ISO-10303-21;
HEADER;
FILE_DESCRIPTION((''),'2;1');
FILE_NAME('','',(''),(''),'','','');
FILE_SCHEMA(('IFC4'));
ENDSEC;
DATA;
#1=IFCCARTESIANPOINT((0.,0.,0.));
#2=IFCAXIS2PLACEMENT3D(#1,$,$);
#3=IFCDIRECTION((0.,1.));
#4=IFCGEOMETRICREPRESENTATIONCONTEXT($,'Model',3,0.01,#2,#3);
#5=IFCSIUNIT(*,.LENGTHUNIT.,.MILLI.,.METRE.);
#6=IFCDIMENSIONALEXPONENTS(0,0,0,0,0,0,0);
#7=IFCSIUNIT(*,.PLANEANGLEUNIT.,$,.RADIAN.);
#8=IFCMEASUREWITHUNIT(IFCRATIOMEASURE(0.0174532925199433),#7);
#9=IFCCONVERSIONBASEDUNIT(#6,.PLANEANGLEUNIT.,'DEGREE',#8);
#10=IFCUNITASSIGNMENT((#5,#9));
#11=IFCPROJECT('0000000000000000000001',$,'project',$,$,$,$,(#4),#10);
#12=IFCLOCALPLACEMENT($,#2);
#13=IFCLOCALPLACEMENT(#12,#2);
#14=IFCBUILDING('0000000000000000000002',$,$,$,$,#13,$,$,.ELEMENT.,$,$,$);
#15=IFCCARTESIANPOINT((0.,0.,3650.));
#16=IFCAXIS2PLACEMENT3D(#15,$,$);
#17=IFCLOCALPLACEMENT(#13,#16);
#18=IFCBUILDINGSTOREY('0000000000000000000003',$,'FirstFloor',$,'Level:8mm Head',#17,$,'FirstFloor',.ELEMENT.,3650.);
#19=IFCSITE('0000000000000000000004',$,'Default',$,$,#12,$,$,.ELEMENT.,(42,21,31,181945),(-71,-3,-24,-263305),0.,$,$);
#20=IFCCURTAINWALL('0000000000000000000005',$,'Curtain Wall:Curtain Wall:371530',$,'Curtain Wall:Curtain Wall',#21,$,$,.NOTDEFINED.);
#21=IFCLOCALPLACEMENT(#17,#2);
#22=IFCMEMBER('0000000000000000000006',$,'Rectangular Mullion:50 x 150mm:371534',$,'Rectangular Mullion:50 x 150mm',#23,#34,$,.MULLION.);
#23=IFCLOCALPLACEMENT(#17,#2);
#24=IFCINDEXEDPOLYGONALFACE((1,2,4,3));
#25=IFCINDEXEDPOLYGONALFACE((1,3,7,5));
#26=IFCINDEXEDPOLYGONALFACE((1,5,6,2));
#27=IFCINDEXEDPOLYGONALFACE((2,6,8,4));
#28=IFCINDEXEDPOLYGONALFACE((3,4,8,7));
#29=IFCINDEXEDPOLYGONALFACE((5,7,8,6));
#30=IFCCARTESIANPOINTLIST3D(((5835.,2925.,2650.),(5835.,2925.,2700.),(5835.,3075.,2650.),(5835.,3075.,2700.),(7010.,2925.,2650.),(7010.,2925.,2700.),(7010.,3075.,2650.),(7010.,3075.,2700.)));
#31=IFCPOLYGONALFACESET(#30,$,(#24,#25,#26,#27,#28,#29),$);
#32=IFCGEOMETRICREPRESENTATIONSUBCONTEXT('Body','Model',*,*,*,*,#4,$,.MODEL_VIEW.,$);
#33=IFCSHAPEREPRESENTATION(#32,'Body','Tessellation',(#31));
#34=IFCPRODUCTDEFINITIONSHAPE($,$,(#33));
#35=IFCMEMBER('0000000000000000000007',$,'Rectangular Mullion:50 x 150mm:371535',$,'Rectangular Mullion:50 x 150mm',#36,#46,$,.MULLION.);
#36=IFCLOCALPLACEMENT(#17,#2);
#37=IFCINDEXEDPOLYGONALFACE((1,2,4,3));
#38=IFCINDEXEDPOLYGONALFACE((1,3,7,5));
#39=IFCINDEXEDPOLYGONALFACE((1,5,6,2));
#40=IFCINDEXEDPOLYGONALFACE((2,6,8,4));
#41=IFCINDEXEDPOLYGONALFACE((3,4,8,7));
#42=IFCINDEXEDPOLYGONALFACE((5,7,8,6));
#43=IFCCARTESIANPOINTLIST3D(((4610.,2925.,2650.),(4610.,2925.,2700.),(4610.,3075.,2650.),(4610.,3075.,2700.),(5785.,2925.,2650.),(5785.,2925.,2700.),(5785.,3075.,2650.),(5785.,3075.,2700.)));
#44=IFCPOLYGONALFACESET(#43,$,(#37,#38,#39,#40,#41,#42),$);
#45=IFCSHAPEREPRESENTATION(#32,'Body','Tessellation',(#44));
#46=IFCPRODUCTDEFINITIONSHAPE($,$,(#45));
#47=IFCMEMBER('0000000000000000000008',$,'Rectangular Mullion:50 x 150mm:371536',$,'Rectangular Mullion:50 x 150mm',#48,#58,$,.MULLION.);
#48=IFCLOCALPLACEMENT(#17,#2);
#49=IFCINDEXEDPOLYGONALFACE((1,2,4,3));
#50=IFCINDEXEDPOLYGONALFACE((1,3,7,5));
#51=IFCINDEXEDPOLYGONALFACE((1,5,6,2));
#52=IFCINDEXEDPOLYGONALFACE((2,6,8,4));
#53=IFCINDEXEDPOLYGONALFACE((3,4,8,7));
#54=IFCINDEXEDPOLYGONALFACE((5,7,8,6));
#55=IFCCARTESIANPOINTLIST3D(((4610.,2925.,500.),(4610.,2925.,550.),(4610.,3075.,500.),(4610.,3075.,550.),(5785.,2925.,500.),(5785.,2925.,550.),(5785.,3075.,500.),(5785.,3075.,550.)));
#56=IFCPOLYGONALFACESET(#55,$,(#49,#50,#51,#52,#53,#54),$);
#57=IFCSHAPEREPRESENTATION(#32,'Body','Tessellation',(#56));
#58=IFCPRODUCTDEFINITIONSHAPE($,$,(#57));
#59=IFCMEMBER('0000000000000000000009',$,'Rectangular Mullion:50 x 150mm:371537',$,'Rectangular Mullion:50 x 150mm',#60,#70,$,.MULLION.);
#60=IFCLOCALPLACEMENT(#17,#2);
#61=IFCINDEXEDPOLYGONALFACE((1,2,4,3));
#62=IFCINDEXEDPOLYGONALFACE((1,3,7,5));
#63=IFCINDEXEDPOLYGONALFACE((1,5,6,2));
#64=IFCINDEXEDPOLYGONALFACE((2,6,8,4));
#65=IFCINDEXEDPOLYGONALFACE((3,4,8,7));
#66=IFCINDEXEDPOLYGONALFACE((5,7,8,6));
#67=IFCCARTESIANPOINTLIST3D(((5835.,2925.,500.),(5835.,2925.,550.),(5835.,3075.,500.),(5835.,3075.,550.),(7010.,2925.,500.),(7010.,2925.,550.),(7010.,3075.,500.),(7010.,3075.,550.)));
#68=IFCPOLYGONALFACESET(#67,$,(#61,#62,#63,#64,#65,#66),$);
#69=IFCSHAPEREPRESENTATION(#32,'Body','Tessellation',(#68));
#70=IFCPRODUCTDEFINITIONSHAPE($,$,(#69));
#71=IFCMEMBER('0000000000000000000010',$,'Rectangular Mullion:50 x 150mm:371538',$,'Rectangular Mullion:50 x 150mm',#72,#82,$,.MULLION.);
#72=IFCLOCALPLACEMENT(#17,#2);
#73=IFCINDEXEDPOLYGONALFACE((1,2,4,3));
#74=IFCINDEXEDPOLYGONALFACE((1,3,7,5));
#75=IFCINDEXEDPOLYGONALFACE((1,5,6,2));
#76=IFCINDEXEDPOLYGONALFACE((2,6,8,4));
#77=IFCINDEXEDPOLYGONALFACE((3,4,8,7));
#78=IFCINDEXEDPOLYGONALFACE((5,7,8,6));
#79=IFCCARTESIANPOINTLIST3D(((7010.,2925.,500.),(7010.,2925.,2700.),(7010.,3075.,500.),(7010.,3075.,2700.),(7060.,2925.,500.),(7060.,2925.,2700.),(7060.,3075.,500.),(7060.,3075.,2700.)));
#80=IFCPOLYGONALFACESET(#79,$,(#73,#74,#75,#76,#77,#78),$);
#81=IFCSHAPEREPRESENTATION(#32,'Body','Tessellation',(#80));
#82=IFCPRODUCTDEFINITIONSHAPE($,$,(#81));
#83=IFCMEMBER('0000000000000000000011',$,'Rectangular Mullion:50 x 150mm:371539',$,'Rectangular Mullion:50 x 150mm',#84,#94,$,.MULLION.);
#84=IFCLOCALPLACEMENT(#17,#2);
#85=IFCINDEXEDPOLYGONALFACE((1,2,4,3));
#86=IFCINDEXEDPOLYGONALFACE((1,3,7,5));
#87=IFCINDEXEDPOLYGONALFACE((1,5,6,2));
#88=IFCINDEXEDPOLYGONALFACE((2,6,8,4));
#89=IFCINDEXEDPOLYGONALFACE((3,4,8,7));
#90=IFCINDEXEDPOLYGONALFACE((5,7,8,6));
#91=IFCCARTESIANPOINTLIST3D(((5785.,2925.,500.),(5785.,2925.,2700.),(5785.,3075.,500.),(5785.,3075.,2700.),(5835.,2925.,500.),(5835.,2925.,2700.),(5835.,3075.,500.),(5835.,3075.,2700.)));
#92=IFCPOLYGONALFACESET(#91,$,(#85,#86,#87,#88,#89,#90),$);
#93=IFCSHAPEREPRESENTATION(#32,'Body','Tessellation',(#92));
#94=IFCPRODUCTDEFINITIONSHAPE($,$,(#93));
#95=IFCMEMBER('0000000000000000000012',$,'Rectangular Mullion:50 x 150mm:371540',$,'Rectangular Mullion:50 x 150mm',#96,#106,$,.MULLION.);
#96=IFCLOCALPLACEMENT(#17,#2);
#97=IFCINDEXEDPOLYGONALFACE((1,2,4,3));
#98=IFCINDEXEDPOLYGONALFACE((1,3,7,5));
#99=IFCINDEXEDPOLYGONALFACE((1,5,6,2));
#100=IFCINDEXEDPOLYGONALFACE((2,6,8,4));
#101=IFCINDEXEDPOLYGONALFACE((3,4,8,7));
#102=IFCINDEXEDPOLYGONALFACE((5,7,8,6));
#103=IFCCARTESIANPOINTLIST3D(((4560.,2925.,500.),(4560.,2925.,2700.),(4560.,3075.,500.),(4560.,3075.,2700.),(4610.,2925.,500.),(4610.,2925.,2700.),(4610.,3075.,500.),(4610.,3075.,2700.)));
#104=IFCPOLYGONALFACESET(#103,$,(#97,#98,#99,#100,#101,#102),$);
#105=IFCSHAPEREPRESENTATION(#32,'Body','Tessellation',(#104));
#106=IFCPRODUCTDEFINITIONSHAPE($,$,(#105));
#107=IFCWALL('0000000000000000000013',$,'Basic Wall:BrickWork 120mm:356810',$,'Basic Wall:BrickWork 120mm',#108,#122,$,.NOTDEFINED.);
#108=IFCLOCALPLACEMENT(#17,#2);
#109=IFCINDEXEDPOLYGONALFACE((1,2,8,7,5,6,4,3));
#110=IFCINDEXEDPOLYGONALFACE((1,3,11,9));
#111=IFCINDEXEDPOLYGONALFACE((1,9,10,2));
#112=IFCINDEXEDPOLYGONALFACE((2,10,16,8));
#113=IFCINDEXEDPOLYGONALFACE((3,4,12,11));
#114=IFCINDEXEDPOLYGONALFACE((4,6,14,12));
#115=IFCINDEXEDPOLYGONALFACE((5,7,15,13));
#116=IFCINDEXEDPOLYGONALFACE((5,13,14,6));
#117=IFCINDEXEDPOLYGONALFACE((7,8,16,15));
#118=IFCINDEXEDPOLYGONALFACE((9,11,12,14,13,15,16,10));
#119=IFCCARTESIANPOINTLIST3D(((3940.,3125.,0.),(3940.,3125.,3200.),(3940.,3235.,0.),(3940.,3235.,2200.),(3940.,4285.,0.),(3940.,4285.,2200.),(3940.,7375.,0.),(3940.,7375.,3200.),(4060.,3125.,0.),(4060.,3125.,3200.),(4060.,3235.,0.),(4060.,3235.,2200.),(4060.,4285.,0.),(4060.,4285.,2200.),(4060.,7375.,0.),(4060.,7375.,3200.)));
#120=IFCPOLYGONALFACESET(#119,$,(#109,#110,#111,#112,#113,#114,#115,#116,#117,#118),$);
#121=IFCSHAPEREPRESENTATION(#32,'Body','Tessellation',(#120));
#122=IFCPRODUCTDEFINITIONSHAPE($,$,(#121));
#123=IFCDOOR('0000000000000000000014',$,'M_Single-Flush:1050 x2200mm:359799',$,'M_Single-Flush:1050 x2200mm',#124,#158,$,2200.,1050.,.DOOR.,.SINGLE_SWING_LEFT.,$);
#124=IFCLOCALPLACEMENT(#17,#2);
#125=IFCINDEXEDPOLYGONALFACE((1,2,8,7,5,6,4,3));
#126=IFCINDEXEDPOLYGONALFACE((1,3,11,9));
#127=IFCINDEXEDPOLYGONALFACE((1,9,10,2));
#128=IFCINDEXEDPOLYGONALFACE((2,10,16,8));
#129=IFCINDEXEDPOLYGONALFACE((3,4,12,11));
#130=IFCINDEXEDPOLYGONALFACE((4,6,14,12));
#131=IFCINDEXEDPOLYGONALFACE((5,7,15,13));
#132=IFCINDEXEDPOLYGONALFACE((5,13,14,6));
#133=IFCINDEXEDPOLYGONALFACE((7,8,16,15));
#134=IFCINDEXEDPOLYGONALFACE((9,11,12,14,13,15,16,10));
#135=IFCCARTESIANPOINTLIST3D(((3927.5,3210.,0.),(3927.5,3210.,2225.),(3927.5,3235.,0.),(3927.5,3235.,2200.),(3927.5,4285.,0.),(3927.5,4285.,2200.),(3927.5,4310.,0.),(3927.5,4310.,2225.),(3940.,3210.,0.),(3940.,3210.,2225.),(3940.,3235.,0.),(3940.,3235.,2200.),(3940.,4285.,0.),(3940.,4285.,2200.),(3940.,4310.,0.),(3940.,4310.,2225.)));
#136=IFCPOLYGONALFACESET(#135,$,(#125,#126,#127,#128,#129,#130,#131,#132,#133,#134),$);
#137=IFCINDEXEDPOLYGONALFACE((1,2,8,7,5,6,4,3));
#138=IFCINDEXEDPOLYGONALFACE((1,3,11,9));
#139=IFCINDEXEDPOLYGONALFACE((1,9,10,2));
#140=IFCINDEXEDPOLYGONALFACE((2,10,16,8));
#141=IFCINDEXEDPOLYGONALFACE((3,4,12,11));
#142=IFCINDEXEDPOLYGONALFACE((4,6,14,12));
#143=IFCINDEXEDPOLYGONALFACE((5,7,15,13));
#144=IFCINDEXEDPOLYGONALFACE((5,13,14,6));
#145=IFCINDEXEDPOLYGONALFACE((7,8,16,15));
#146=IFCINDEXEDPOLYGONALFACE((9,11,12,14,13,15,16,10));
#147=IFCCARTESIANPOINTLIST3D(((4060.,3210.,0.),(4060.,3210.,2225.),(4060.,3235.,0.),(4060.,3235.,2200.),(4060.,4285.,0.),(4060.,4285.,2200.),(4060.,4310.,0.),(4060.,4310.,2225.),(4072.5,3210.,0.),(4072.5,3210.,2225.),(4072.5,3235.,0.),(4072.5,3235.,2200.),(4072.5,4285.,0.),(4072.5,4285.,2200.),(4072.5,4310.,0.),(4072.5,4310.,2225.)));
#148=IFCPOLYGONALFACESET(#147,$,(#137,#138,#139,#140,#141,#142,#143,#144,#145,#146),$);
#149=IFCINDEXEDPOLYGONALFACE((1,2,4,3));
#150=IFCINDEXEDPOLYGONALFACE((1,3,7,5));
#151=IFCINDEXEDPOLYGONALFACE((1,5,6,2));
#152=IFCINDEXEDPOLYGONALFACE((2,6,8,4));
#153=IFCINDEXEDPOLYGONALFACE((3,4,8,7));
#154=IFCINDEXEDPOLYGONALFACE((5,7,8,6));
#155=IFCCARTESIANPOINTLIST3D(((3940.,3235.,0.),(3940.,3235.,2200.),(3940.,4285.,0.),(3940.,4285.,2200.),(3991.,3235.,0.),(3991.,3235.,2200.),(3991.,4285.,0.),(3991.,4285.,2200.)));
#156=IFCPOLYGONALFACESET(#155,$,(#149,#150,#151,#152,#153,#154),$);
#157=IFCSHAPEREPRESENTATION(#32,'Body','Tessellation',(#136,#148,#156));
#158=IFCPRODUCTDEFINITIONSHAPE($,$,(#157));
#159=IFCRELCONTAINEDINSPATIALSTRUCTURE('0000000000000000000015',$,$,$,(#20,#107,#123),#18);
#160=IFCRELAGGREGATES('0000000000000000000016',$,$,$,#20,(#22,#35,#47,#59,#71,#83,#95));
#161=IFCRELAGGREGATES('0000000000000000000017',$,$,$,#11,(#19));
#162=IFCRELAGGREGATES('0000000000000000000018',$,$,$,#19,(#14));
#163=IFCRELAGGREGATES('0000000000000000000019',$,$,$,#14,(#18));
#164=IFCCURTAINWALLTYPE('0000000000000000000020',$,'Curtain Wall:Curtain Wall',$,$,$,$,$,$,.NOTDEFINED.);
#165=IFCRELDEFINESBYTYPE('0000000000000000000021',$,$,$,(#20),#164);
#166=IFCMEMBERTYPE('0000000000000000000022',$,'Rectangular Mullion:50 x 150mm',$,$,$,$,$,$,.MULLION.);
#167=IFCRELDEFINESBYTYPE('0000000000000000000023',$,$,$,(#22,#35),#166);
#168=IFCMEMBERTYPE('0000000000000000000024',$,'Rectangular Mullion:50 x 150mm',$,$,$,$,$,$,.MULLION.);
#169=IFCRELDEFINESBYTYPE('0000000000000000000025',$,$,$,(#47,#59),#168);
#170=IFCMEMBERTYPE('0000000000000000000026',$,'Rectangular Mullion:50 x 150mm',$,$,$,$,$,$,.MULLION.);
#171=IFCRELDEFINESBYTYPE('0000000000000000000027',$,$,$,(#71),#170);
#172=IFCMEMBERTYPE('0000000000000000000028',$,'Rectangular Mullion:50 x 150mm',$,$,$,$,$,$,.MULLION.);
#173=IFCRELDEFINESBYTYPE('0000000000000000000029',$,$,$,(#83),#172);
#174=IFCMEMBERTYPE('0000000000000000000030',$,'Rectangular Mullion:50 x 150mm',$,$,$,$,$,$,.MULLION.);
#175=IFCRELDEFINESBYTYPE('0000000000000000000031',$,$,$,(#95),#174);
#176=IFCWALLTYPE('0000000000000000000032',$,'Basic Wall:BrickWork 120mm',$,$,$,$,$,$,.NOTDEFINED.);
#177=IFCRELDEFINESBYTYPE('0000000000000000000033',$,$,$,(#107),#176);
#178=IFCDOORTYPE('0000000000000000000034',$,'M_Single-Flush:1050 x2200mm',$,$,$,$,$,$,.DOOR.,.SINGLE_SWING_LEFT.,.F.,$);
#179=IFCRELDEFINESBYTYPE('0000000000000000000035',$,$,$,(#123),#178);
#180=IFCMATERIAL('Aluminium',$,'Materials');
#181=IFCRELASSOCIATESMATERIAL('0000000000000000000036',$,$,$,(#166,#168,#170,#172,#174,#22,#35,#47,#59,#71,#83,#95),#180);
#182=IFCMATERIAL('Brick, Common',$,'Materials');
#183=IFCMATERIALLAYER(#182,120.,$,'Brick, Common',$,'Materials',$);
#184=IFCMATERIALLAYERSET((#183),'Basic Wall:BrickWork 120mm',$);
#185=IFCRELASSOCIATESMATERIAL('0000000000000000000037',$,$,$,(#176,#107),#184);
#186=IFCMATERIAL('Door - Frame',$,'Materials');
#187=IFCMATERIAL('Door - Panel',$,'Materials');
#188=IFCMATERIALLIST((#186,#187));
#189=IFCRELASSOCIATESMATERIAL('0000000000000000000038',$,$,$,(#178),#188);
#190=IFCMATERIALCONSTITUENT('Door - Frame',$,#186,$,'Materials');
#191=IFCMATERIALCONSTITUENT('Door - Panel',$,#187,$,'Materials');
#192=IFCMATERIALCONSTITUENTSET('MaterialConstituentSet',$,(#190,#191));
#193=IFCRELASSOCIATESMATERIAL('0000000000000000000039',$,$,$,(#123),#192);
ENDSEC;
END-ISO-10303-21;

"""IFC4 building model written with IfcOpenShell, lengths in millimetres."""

from ifc_helpers import new_model, entity, si_unit, converted_unit, direction, frame, frame_2d, origin, origin_2d_with_axis, place, context, subcontext, project, spatial, polyline, rectangle, outline, extrude, source, transform, mapped, material, material_list, layer, layer_set, layer_usage, constituent, constituent_set, material_profile, profile_set, profile_usage, type_object, type_shapes, element, fill, aggregate, save


model = new_model("IFC4")

# Units and contexts
model_context = context("Model", 3, precision=0.01, world=origin(), true_north=direction((0.0, 1.0)))
body_context = subcontext(model_context, "Body", "Model", "MODEL_VIEW")
ifc_project = project(units=[si_unit("LENGTHUNIT", "METRE", prefix="MILLI"), converted_unit("PLANEANGLEUNIT", "DEGREE", entity("IfcRatioMeasure", 0.0174532925199433), si_unit("PLANEANGLEUNIT", "RADIAN"), dimensions=[0, 0, 0, 0, 0, 0, 0])], contexts=[model_context])

# Site, building, storey
site_placement = place(None, origin())
site = spatial("IfcSite", under=ifc_project, at=site_placement, Name="Default", CompositionType="ELEMENT", RefLatitude=(42, 21, 31, 181945), RefLongitude=(-71, -3, -24, -263305), RefElevation=0.0)
building_placement = place(site_placement, origin())
building = spatial("IfcBuilding", under=site, at=building_placement, CompositionType="ELEMENT")
storey_placement = place(building_placement, frame((0.0, 0.0, 3650.0)))
storey = spatial("IfcBuildingStorey", under=building, at=storey_placement, Name="FirstFloor", ObjectType="Level:8mm Head", LongName="FirstFloor", CompositionType="ELEMENT", Elevation=3650.0)

# Curtain wall, members
curtain_wall_type = type_object("IfcCurtainWallType", Name="Curtain Wall:Curtain Wall", PredefinedType="NOTDEFINED")
curtain_wall_placement = place(storey_placement, frame((0.0, 0.0, -3650.0)))
curtain_wall = element("IfcCurtainWall", 1, at=curtain_wall_placement, inside=storey, type_object=curtain_wall_type, Name="Curtain Wall:Curtain Wall:371530", ObjectType="Curtain Wall:Curtain Wall", PredefinedType="NOTDEFINED")
ifc_material_1 = material(Name="Aluminium", Category="Materials")
ifc_material_profile = material_profile(ifc_material_1, rectangle(XDim=150.0, YDim=50.0, at=origin_2d_with_axis()), Name="50 x 150mm")
ifc_profile_set = profile_set([ifc_material_profile], Name="50 x 150mm")
ifc_profile_usage_1 = profile_usage(ifc_profile_set)
member_type_1 = type_object("IfcMemberType", Name="Rectangular Mullion:50 x 150mm", PredefinedType="MULLION", material=ifc_profile_set)
shared_shape_1 = source(origin(), body_context, "Body", "SweptSolid", [
    extrude(rectangle(XDim=150.0, YDim=50.0, at=origin_2d_with_axis()), frame((-25.0, 0.0, -1175.0), z_axis=(0.0, 0.0, 1.0), x_axis=(0.0, -1.0, 0.0)), (0.0, 0.0, 1.0), 1175.0),
])
type_shapes(member_type_1, [shared_shape_1])
member_1_placement = place(storey_placement, frame((7010.0, 3000.0, 2700.0), z_axis=(1.0, 0.0, 0.0), x_axis=(0.0, 0.0, 1.0)))
member_1 = element("IfcMember", 2, at=member_1_placement, type_object=member_type_1, material=ifc_profile_usage_1, Name="Rectangular Mullion:50 x 150mm:371534", ObjectType="Rectangular Mullion:50 x 150mm", PredefinedType="MULLION", context=body_context, shape_type="MappedRepresentation", body=[
    mapped(shared_shape_1, transform((0.0, 0.0, 0.0), scale=1.0)),
])
ifc_profile_usage_2 = profile_usage(ifc_profile_set)
member_2_placement = place(storey_placement, frame((5785.0, 3000.0, 2700.0), z_axis=(1.0, 0.0, 0.0), x_axis=(0.0, 0.0, 1.0)))
member_2 = element("IfcMember", 3, at=member_2_placement, type_object=member_type_1, material=ifc_profile_usage_2, Name="Rectangular Mullion:50 x 150mm:371535", ObjectType="Rectangular Mullion:50 x 150mm", PredefinedType="MULLION", context=body_context, shape_type="MappedRepresentation", body=[
    mapped(shared_shape_1, transform((0.0, 0.0, 0.0), scale=1.0)),
])
ifc_profile_usage_3 = profile_usage(ifc_profile_set)
member_type_2 = type_object("IfcMemberType", Name="Rectangular Mullion:50 x 150mm", PredefinedType="MULLION", material=ifc_profile_set)
shared_shape_2 = source(origin(), body_context, "Body", "SweptSolid", [
    extrude(rectangle(XDim=150.0, YDim=50.0, at=origin_2d_with_axis()), frame((-25.0, 0.0, -1175.0), z_axis=(0.0, 0.0, 1.0), x_axis=(0.0, -1.0, 0.0)), (0.0, 0.0, 1.0), 1175.0),
])
type_shapes(member_type_2, [shared_shape_2])
member_3_placement = place(storey_placement, frame((4610.0, 3000.0, 500.0), z_axis=(-1.0, 0.0, 0.0), x_axis=(0.0, 0.0, -1.0)))
member_3 = element("IfcMember", 4, at=member_3_placement, type_object=member_type_2, material=ifc_profile_usage_3, Name="Rectangular Mullion:50 x 150mm:371536", ObjectType="Rectangular Mullion:50 x 150mm", PredefinedType="MULLION", context=body_context, shape_type="MappedRepresentation", body=[
    mapped(shared_shape_2, transform((0.0, 0.0, 0.0), scale=1.0)),
])
ifc_profile_usage_4 = profile_usage(ifc_profile_set)
member_4_placement = place(storey_placement, frame((5835.0, 3000.0, 500.0), z_axis=(-1.0, 0.0, 0.0), x_axis=(0.0, 0.0, -1.0)))
member_4 = element("IfcMember", 5, at=member_4_placement, type_object=member_type_2, material=ifc_profile_usage_4, Name="Rectangular Mullion:50 x 150mm:371537", ObjectType="Rectangular Mullion:50 x 150mm", PredefinedType="MULLION", context=body_context, shape_type="MappedRepresentation", body=[
    mapped(shared_shape_2, transform((0.0, 0.0, 0.0), scale=1.0)),
])
ifc_profile_usage_5 = profile_usage(ifc_profile_set)
member_type_3 = type_object("IfcMemberType", Name="Rectangular Mullion:50 x 150mm", PredefinedType="MULLION", material=ifc_profile_set)
shared_shape_3 = source(origin(), body_context, "Body", "SweptSolid", [
    extrude(rectangle(XDim=150.0, YDim=50.0, at=origin_2d_with_axis()), frame((-25.0, 0.0, -2200.0), z_axis=(0.0, 0.0, 1.0), x_axis=(0.0, -1.0, 0.0)), (0.0, 0.0, 1.0), 2200.0),
])
type_shapes(member_type_3, [shared_shape_3])
member_5_placement = place(storey_placement, frame((7060.0, 3000.0, 500.0), z_axis=(0.0, 0.0, -1.0), x_axis=(1.0, 0.0, 0.0)))
member_5 = element("IfcMember", 6, at=member_5_placement, type_object=member_type_3, material=ifc_profile_usage_5, Name="Rectangular Mullion:50 x 150mm:371538", ObjectType="Rectangular Mullion:50 x 150mm", PredefinedType="MULLION", context=body_context, shape_type="MappedRepresentation", body=[
    mapped(shared_shape_3, transform((0.0, 0.0, 0.0), scale=1.0)),
])
ifc_profile_usage_6 = profile_usage(ifc_profile_set)
member_type_4 = type_object("IfcMemberType", Name="Rectangular Mullion:50 x 150mm", PredefinedType="MULLION", material=ifc_profile_set)
shared_shape_4 = source(origin(), body_context, "Body", "SweptSolid", [
    extrude(rectangle(XDim=150.0, YDim=50.0, at=origin_2d_with_axis()), frame((0.0, 0.0, -2200.0), z_axis=(0.0, 0.0, 1.0), x_axis=(0.0, -1.0, 0.0)), (0.0, 0.0, 1.0), 2200.0),
])
type_shapes(member_type_4, [shared_shape_4])
member_6_placement = place(storey_placement, frame((5810.0, 3000.0, 500.0), z_axis=(0.0, 0.0, -1.0), x_axis=(1.0, 0.0, 0.0)))
member_6 = element("IfcMember", 7, at=member_6_placement, type_object=member_type_4, material=ifc_profile_usage_6, Name="Rectangular Mullion:50 x 150mm:371539", ObjectType="Rectangular Mullion:50 x 150mm", PredefinedType="MULLION", context=body_context, shape_type="MappedRepresentation", body=[
    mapped(shared_shape_4, transform((0.0, 0.0, 0.0), scale=1.0)),
])
ifc_profile_usage_7 = profile_usage(ifc_profile_set)
member_type_5 = type_object("IfcMemberType", Name="Rectangular Mullion:50 x 150mm", PredefinedType="MULLION", material=ifc_profile_set)
shared_shape_5 = source(origin(), body_context, "Body", "SweptSolid", [
    extrude(rectangle(XDim=150.0, YDim=50.0, at=origin_2d_with_axis()), frame((-25.0, 0.0, -2200.0), z_axis=(0.0, 0.0, 1.0), x_axis=(0.0, -1.0, 0.0)), (0.0, 0.0, 1.0), 2200.0),
])
type_shapes(member_type_5, [shared_shape_5])
member_7_placement = place(storey_placement, frame((4560.0, 3000.0, 2700.0), z_axis=(0.0, 0.0, 1.0), x_axis=(-1.0, 0.0, 0.0)))
member_7 = element("IfcMember", 8, at=member_7_placement, type_object=member_type_5, material=ifc_profile_usage_7, Name="Rectangular Mullion:50 x 150mm:371540", ObjectType="Rectangular Mullion:50 x 150mm", PredefinedType="MULLION", context=body_context, shape_type="MappedRepresentation", body=[
    mapped(shared_shape_5, transform((0.0, 0.0, 0.0), scale=1.0)),
])

aggregate(curtain_wall, [member_1, member_2, member_3, member_4, member_5, member_6, member_7])

# Wall, opening, door
ifc_material_2 = material(Name="Brick, Common", Category="Materials")
ifc_layer_1 = layer(ifc_material_2, 120.0, Name="Brick, Common", Category="Materials")
ifc_layer_set_1 = layer_set([ifc_layer_1], Name="Basic Wall:BrickWork 120mm")
ifc_layer_usage_1 = layer_usage(ifc_layer_set_1, "AXIS2", "NEGATIVE", 60.0)
wall_type = type_object("IfcWallType", Name="Basic Wall:BrickWork 120mm", PredefinedType="NOTDEFINED", material=ifc_layer_set_1)
wall_placement = place(storey_placement, frame((4000.0, 7375.0, 0.0), z_axis=(0.0, 0.0, 1.0), x_axis=(0.0, -1.0, 0.0)))
wall = element("IfcWall", 9, at=wall_placement, inside=storey, type_object=wall_type, material=ifc_layer_usage_1, Name="Basic Wall:BrickWork 120mm:356810", ObjectType="Basic Wall:BrickWork 120mm", PredefinedType="NOTDEFINED", context=body_context, shape_type="SweptSolid", body=[
    extrude(rectangle(XDim=4250.0, YDim=120.0, at=frame_2d((2125.0, 0.0), x_axis=(-1.0, 0.0))), origin(), (0.0, 0.0, 1.0), 3200.0),
])
opening_placement = place(wall_placement, frame((4140.0, 60.0, 0.0)))
opening = element("IfcOpeningElement", 10, at=opening_placement, cuts=wall, ObjectType="Opening", PredefinedType="OPENING", context=body_context, shape_type="SweptSolid", body=[
    extrude(rectangle(XDim=1050.0, YDim=2200.0, at=frame_2d((1100.0, 525.0), x_axis=(0.0, -1.0))), frame((0.0, 0.0, 0.0), z_axis=(0.0, -1.0, 0.0), x_axis=(0.0, 0.0, 1.0)), (0.0, 0.0, 1.0), 120.0),
])
ifc_material_3 = material(Name="Door - Frame", Category="Materials")
ifc_constituent_1 = constituent(ifc_material_3, Name="Door - Frame", Category="Materials")
ifc_material_4 = material(Name="Door - Panel", Category="Materials")
ifc_constituent_2 = constituent(ifc_material_4, Name="Door - Panel", Category="Materials")
ifc_constituent_set_1 = constituent_set(constituents=[ifc_constituent_1, ifc_constituent_2], Name="MaterialConstituentSet")
ifc_material_list_1 = material_list([ifc_material_3, ifc_material_4])
door_type = type_object("IfcDoorType", Name="M_Single-Flush:1050 x2200mm", OperationType="SINGLE_SWING_LEFT", ParameterTakesPrecedence=False, PredefinedType="DOOR", material=ifc_material_list_1)
shared_shape_6 = source(origin(), body_context, "Body", "SweptSolid", [
    extrude(outline(polyline([(-550.0, -1118.8), (550.0, -1118.8), (550.0, 1106.2), (525.0, 1106.2), (525.0, -1093.8), (-525.0, -1093.8), (-525.0, 1106.2), (-550.0, 1106.2), (-550.0, -1118.8)])), frame((525.0, 132.5, 1106.2), z_axis=(0.0, -1.0, 0.0), x_axis=(-1.0, 0.0, 0.0)), (0.0, 0.0, 1.0), 12.5),
    extrude(outline(polyline([(-1118.8, -550.0), (1106.2, -550.0), (1106.2, -525.0), (-1093.8, -525.0), (-1093.8, 525.0), (1106.2, 525.0), (1106.2, 550.0), (-1118.8, 550.0), (-1118.8, -550.0)])), frame((525.0, 0.0, 1106.2), z_axis=(0.0, -1.0, 0.0), x_axis=(0.0, 0.0, -1.0)), (0.0, 0.0, 1.0), 12.5),
    extrude(rectangle(XDim=1050.0, YDim=51.0, at=frame_2d((0.0, 0.0), x_axis=(1.0, 0.0))), frame((525.0, 94.5, 0.0)), (0.0, 0.0, 1.0), 2200.0),
])
type_shapes(door_type, [shared_shape_6])
door_placement = place(opening_placement, frame((0.0, 0.0, 0.0), z_axis=(0.0, 0.0, 1.0), x_axis=(-1.0, 0.0, 0.0)))
door = element("IfcDoor", 11, at=door_placement, inside=storey, type_object=door_type, material=ifc_constituent_set_1, Name="M_Single-Flush:1050 x2200mm:359799", ObjectType="M_Single-Flush:1050 x2200mm", OperationType="SINGLE_SWING_LEFT", OverallHeight=2200.0, OverallWidth=1050.0, PredefinedType="DOOR", context=body_context, shape_type="MappedRepresentation", body=[
    mapped(shared_shape_6, transform((0.0, 0.0, 0.0), scale=1.0)),
])
fill(opening, door)

save(model, "model.ifc")
